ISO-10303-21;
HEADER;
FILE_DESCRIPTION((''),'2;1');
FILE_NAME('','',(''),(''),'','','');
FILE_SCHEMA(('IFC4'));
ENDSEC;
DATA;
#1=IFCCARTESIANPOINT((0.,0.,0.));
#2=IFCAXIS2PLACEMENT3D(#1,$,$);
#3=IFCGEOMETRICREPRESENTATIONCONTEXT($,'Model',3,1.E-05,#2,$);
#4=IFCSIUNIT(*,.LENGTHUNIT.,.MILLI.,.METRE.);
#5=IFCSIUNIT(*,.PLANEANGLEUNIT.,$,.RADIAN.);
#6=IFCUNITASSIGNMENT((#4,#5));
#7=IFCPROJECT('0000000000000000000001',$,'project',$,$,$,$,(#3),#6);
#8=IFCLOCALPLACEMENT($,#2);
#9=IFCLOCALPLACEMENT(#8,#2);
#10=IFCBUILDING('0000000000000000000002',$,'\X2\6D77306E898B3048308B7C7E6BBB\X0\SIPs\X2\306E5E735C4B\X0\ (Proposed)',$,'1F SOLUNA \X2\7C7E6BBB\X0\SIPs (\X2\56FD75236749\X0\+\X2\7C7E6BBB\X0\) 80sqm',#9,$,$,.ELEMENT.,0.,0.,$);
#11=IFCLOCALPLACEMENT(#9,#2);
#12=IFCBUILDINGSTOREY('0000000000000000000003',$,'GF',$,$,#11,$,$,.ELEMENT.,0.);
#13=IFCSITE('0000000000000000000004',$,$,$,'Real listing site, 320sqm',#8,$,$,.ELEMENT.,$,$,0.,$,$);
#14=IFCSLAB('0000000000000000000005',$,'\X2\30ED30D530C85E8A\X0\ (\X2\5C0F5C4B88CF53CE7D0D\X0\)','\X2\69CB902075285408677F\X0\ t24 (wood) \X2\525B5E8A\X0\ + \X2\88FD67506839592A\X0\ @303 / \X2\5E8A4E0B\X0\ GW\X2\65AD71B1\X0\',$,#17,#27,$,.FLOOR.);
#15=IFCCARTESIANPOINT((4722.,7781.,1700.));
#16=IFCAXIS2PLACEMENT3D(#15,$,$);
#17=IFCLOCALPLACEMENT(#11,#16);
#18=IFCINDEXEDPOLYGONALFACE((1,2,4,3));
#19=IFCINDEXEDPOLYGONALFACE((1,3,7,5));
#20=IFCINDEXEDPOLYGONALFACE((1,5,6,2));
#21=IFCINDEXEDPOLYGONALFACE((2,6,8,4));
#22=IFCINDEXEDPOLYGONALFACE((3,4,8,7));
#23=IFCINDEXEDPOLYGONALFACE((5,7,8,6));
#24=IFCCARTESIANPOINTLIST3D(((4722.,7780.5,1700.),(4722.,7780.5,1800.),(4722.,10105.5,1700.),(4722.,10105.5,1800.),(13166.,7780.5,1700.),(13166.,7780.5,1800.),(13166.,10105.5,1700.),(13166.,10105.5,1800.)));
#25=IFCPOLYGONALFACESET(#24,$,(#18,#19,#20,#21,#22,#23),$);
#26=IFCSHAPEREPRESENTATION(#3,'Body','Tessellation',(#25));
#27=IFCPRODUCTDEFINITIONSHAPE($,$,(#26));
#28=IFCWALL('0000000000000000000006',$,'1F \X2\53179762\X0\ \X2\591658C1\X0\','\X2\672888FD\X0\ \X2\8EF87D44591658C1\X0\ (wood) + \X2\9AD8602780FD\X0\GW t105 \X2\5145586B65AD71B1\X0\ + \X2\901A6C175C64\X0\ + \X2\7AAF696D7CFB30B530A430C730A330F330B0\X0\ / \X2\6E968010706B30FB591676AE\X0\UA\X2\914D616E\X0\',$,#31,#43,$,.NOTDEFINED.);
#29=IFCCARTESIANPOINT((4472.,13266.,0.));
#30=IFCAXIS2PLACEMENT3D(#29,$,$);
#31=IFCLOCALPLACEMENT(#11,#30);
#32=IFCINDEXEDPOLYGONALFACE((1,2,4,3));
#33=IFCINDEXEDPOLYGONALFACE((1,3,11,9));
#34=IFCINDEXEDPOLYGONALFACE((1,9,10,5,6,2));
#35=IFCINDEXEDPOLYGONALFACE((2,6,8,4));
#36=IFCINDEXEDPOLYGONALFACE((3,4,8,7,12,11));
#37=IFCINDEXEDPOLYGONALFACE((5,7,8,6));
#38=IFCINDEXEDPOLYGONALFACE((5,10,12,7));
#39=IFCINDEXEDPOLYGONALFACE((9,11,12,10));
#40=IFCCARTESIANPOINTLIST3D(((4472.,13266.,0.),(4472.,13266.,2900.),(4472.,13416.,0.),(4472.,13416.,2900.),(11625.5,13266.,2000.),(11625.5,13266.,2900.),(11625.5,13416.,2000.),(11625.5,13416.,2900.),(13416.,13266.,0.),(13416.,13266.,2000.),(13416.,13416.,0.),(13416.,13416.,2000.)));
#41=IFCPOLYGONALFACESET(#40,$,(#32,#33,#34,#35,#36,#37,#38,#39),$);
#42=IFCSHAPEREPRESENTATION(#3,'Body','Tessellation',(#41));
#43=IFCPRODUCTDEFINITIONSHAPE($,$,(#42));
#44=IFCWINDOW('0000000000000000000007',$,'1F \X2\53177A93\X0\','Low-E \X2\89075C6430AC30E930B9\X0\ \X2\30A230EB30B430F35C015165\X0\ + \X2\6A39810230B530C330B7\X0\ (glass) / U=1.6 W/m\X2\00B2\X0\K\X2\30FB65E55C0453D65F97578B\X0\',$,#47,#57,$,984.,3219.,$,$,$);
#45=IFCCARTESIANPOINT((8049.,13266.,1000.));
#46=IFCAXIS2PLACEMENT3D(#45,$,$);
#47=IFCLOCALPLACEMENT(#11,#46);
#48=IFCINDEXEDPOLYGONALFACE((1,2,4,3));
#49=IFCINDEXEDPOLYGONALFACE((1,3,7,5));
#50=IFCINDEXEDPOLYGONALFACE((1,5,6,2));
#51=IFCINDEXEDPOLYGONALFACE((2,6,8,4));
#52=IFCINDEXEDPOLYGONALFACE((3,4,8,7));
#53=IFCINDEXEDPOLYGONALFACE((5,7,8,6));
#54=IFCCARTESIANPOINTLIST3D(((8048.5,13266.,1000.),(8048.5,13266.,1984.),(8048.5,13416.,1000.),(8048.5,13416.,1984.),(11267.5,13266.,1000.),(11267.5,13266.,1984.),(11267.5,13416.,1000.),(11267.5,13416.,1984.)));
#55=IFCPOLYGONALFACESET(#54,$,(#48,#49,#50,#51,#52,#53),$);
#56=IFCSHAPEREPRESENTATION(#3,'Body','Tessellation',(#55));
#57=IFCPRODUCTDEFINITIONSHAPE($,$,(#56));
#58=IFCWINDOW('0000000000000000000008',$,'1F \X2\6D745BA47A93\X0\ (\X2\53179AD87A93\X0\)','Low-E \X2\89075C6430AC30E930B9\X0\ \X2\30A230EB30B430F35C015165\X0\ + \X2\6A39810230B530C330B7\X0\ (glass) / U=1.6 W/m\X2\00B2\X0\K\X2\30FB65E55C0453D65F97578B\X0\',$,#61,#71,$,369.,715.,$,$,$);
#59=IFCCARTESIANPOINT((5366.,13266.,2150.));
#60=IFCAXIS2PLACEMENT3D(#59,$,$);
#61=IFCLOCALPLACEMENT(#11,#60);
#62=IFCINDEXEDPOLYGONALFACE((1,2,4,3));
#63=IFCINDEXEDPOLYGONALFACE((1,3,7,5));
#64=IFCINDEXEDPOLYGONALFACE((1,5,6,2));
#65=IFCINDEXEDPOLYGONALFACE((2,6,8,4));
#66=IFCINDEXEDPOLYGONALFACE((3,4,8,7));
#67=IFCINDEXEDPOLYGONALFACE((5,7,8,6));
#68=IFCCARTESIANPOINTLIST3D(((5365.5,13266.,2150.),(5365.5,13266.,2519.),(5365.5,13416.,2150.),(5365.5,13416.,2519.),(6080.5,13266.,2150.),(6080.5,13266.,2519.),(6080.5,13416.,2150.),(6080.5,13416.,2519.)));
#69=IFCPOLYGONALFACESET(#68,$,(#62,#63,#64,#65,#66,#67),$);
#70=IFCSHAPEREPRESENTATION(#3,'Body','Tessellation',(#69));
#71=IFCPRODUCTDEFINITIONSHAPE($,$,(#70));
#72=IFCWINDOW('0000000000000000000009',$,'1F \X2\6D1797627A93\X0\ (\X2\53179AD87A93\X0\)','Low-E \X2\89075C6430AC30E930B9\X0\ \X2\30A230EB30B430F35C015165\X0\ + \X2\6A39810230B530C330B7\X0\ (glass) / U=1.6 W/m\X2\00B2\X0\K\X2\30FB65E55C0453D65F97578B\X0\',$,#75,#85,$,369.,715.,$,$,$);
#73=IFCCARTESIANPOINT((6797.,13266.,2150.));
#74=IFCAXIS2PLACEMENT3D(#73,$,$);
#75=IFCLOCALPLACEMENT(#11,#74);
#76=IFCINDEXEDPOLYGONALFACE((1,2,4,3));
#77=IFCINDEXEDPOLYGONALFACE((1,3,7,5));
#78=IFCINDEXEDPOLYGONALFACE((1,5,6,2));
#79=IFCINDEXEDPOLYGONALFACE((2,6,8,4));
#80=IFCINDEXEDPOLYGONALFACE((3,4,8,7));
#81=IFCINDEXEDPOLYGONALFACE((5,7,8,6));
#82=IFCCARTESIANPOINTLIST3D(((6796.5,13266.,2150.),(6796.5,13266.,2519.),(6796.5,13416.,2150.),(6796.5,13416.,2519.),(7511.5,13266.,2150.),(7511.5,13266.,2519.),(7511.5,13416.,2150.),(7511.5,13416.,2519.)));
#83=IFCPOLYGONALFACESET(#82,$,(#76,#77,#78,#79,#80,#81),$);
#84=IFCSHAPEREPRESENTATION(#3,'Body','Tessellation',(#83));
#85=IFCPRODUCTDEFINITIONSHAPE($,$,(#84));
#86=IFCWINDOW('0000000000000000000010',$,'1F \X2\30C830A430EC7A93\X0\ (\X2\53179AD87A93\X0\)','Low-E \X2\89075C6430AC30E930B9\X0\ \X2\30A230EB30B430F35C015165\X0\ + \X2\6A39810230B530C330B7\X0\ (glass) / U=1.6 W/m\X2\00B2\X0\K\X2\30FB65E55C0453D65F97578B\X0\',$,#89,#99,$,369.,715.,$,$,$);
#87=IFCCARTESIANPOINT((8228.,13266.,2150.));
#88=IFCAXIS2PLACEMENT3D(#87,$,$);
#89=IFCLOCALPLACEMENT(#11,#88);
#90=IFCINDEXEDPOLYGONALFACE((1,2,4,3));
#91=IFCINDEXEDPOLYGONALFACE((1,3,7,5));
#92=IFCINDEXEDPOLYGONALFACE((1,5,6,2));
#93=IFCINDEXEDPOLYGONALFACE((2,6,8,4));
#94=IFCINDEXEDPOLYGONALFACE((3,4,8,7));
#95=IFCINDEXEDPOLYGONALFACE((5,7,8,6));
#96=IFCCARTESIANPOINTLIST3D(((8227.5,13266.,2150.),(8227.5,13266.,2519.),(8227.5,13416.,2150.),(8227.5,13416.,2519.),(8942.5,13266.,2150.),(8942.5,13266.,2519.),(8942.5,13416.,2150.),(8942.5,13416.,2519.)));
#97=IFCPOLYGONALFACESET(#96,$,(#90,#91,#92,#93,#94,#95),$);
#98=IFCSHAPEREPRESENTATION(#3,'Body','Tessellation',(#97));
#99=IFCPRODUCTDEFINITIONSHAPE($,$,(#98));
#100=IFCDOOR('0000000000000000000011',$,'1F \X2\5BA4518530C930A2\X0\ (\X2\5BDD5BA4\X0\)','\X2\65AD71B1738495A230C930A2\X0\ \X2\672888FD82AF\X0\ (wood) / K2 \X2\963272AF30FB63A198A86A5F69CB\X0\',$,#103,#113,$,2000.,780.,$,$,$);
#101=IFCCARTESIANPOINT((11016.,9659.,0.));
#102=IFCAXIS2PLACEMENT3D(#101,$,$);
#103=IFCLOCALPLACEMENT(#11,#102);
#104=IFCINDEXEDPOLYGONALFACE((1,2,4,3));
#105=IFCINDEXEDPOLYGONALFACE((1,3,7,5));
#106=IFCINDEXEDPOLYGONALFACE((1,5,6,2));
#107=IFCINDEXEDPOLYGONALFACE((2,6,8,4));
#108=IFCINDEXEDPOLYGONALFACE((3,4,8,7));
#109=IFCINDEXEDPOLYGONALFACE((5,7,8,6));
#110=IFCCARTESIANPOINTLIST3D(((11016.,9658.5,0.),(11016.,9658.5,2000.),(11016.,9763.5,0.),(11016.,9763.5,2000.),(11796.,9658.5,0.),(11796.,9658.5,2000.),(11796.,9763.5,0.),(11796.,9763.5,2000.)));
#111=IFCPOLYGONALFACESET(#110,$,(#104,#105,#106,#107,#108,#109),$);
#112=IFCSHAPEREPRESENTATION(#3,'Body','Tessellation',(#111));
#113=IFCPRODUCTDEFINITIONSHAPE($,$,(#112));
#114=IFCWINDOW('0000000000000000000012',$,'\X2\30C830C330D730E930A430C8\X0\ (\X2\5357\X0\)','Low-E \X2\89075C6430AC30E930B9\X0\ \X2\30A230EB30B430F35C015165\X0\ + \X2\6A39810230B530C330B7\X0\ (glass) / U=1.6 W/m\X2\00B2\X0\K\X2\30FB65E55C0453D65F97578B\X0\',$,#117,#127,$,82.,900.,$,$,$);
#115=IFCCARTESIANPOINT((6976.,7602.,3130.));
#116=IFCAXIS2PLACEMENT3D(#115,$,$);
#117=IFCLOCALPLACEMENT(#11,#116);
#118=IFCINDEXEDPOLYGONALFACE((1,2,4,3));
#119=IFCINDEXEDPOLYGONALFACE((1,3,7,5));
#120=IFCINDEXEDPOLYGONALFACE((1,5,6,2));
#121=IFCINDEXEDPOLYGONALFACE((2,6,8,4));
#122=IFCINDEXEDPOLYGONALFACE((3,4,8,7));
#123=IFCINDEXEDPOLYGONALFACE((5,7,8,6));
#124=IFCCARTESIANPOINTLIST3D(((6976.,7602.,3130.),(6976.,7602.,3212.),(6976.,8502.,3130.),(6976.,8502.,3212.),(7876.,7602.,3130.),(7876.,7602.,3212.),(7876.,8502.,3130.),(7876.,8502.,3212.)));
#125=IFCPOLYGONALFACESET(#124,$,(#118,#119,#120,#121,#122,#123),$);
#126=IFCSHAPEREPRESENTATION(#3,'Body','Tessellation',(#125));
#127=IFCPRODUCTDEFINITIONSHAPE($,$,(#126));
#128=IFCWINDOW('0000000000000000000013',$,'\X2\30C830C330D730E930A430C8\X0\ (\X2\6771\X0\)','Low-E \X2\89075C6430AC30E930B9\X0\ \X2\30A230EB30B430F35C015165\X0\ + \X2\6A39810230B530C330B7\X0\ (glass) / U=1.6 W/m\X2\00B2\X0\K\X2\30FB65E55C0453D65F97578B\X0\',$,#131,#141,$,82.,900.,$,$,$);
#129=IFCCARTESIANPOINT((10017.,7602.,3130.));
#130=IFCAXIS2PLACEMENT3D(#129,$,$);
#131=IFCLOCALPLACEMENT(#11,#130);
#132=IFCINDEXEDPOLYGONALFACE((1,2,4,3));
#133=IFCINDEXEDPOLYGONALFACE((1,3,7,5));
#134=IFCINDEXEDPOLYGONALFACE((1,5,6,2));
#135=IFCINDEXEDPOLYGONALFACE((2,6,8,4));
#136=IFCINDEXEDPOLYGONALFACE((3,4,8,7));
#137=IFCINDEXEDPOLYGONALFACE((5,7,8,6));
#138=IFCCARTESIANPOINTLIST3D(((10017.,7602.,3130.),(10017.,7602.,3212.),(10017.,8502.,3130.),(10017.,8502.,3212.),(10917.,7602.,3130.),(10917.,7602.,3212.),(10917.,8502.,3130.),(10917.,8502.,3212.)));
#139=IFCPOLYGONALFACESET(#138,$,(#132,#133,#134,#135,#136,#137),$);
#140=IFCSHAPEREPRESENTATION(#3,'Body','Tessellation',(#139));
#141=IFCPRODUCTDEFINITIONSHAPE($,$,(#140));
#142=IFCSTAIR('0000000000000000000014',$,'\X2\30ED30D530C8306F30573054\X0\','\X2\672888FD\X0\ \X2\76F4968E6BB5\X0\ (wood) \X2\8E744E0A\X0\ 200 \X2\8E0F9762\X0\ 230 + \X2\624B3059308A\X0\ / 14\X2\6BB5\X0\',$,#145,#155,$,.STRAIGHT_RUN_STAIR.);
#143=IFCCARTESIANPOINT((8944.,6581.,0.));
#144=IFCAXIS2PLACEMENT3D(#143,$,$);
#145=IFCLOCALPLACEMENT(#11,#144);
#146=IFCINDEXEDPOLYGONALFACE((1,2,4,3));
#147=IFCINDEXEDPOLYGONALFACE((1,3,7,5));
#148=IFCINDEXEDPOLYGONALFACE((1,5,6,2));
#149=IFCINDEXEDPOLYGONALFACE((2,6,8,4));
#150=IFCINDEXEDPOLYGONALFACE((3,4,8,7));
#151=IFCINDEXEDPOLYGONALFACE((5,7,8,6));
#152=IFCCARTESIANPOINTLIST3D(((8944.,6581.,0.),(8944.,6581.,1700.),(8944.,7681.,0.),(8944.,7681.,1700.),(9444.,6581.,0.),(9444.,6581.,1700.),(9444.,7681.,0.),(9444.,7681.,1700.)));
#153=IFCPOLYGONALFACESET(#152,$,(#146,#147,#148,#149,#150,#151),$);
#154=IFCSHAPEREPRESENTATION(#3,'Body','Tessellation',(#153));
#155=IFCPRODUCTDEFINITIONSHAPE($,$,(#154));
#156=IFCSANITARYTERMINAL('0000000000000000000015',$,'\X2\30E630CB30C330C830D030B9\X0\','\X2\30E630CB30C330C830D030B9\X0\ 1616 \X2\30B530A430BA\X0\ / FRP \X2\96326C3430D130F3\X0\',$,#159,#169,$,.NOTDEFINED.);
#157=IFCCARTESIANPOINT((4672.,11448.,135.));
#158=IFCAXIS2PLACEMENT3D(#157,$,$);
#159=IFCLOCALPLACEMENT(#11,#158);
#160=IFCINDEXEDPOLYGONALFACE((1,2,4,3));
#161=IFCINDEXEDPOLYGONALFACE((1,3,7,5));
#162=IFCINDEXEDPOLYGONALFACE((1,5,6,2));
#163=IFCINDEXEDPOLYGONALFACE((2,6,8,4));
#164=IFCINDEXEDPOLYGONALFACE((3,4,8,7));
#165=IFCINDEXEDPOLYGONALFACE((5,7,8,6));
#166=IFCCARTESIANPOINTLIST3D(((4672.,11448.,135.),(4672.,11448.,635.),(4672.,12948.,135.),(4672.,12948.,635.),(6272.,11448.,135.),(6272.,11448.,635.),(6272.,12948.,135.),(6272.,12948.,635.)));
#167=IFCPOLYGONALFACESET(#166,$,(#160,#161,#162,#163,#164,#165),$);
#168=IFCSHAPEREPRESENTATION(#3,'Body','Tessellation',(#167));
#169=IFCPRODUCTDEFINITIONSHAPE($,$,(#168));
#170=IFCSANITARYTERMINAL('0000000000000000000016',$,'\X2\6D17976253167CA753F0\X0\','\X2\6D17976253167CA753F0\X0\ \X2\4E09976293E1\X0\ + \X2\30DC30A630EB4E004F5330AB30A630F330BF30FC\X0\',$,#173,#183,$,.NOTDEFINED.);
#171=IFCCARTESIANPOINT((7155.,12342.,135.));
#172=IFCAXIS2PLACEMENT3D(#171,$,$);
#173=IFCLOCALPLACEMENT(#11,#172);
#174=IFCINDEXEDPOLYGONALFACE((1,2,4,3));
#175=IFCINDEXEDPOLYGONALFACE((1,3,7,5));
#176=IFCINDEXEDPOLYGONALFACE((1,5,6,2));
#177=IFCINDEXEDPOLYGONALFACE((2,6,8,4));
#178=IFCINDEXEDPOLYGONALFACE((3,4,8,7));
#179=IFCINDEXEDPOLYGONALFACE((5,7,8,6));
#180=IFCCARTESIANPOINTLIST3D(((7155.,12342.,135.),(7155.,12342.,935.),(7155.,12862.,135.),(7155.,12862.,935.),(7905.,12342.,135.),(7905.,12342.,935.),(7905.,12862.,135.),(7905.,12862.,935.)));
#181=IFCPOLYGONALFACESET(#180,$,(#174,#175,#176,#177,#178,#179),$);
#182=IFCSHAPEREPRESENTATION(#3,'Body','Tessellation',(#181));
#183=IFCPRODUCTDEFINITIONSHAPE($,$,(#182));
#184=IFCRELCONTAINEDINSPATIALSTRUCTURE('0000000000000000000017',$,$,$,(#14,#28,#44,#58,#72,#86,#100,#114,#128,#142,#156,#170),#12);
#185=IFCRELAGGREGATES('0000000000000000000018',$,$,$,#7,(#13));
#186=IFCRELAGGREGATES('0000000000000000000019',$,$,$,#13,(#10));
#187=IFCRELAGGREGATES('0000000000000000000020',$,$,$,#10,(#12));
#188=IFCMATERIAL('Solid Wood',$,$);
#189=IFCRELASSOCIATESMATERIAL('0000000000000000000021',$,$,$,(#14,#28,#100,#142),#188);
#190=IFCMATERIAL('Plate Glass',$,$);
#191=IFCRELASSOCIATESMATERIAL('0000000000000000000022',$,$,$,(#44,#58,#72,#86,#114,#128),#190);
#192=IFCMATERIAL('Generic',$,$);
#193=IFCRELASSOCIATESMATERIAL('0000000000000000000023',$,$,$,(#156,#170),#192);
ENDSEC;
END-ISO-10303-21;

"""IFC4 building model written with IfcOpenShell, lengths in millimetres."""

from ifc_helpers import new_model, si_unit, frame, frame_2d, origin, place, context, project, spatial, rectangle, extrude, material, element, fill, save


model = new_model("IFC4")

# Units and contexts
model_context = context("Model", 3, precision=1e-05, world=origin())
ifc_project = project(units=[si_unit("LENGTHUNIT", "METRE", prefix="MILLI"), si_unit("PLANEANGLEUNIT", "RADIAN")], contexts=[model_context])

# Site, building, storey
site_placement = place(None, origin())
site = spatial("IfcSite", under=ifc_project, at=site_placement, ObjectType="Real listing site, 320sqm", CompositionType="ELEMENT", RefElevation=0.0)
building_placement = place(site_placement, origin())
building = spatial("IfcBuilding", under=site, at=building_placement, Name="海の見える籾殻SIPsの平屋 (Proposed)", ObjectType="1F SOLUNA 籾殻SIPs (国産杉+籾殻) 80sqm", CompositionType="ELEMENT", ElevationOfRefHeight=0.0, ElevationOfTerrain=0.0)
storey_placement = place(building_placement, origin())
storey = spatial("IfcBuildingStorey", under=building, at=storey_placement, Name="GF", CompositionType="ELEMENT", Elevation=0.0)

# Slab
ifc_material_1 = material(Name="Solid Wood")
slab_placement = place(storey_placement, frame((4722.0, 7781.0, 1700.0)))
element("IfcSlab", 1, at=slab_placement, inside=storey, material=ifc_material_1, Name="ロフト床 (小屋裏収納)", Description="構造用合板 t24 (wood) 剛床 + 製材根太 @303 / 床下 GW断熱", PredefinedType="FLOOR", context=model_context, shape_type="SweptSolid", body=[
    extrude(rectangle(XDim=8444.0, YDim=2325.0, at=frame_2d((4222.0, 1162.0))), frame((4722.0, 7781.0, 1700.0)), (0.0, 0.0, 1.0), 100.0),
])

# Wall, openings, windows
wall_1_placement = place(storey_placement, frame((4472.0, 13266.0, 0.0)))
wall_1 = element("IfcWall", 2, at=wall_1_placement, inside=storey, material=ifc_material_1, Name="1F 北面 外壁", Description="木製 軸組外壁 (wood) + 高性能GW t105 充填断熱 + 通気層 + 窯業系サイディング / 準耐火・外皮UA配慮", PredefinedType="NOTDEFINED", context=model_context, shape_type="SweptSolid", body=[
    extrude(rectangle(XDim=8944.0, YDim=150.0, at=frame_2d((4472.0, 75.0))), frame((4472.0, 13266.0, 0.0)), (0.0, 0.0, 1.0), 2900.0),
])
opening_1_placement = place(storey_placement, frame((8049.0, 13266.0, 1000.0)))
opening_1 = element("IfcOpeningElement", 3, at=opening_1_placement, cuts=wall_1, PredefinedType="NOTDEFINED", context=model_context, shape_type="SweptSolid", body=[
    extrude(rectangle(XDim=3219.0, YDim=150.0, at=frame_2d((1609.0, 75.0))), frame((8049.0, 13266.0, 1000.0)), (0.0, 0.0, 1.0), 984.0),
])
opening_2_placement = place(storey_placement, frame((5366.0, 13266.0, 2150.0)))
opening_2 = element("IfcOpeningElement", 4, at=opening_2_placement, cuts=wall_1, PredefinedType="NOTDEFINED", context=model_context, shape_type="SweptSolid", body=[
    extrude(rectangle(XDim=715.0, YDim=150.0, at=frame_2d((357.0, 75.0))), frame((5366.0, 13266.0, 2150.0)), (0.0, 0.0, 1.0), 369.0),
])
opening_3_placement = place(storey_placement, frame((6797.0, 13266.0, 2150.0)))
opening_3 = element("IfcOpeningElement", 5, at=opening_3_placement, cuts=wall_1, PredefinedType="NOTDEFINED", context=model_context, shape_type="SweptSolid", body=[
    extrude(rectangle(XDim=715.0, YDim=150.0, at=frame_2d((357.0, 75.0))), frame((6797.0, 13266.0, 2150.0)), (0.0, 0.0, 1.0), 369.0),
])
opening_4_placement = place(storey_placement, frame((8228.0, 13266.0, 2150.0)))
opening_4 = element("IfcOpeningElement", 6, at=opening_4_placement, cuts=wall_1, PredefinedType="NOTDEFINED", context=model_context, shape_type="SweptSolid", body=[
    extrude(rectangle(XDim=715.0, YDim=150.0, at=frame_2d((357.0, 75.0))), frame((8228.0, 13266.0, 2150.0)), (0.0, 0.0, 1.0), 369.0),
])
ifc_material_2 = material(Name="Plate Glass")
window_1_placement = place(storey_placement, frame((8049.0, 13266.0, 1000.0)))
window_1 = element("IfcWindow", 7, at=window_1_placement, inside=storey, material=ifc_material_2, Name="1F 北窓", Description="Low-E 複層ガラス アルゴン封入 + 樹脂サッシ (glass) / U=1.6 W/m²K・日射取得型", OverallHeight=984.0, OverallWidth=3219.0, context=model_context, shape_type="SweptSolid", body=[
    extrude(rectangle(XDim=3219.0, YDim=150.0, at=frame_2d((1609.0, 75.0))), frame((8049.0, 13266.0, 1000.0)), (0.0, 0.0, 1.0), 984.0),
])
fill(opening_1, window_1)
window_2_placement = place(storey_placement, frame((5366.0, 13266.0, 2150.0)))
window_2 = element("IfcWindow", 8, at=window_2_placement, inside=storey, material=ifc_material_2, Name="1F 浴室窓 (北高窓)", Description="Low-E 複層ガラス アルゴン封入 + 樹脂サッシ (glass) / U=1.6 W/m²K・日射取得型", OverallHeight=369.0, OverallWidth=715.0, context=model_context, shape_type="SweptSolid", body=[
    extrude(rectangle(XDim=715.0, YDim=150.0, at=frame_2d((357.0, 75.0))), frame((5366.0, 13266.0, 2150.0)), (0.0, 0.0, 1.0), 369.0),
])
fill(opening_2, window_2)
window_3_placement = place(storey_placement, frame((6797.0, 13266.0, 2150.0)))
window_3 = element("IfcWindow", 9, at=window_3_placement, inside=storey, material=ifc_material_2, Name="1F 洗面窓 (北高窓)", Description="Low-E 複層ガラス アルゴン封入 + 樹脂サッシ (glass) / U=1.6 W/m²K・日射取得型", OverallHeight=369.0, OverallWidth=715.0, context=model_context, shape_type="SweptSolid", body=[
    extrude(rectangle(XDim=715.0, YDim=150.0, at=frame_2d((357.0, 75.0))), frame((6797.0, 13266.0, 2150.0)), (0.0, 0.0, 1.0), 369.0),
])
fill(opening_3, window_3)
window_4_placement = place(storey_placement, frame((8228.0, 13266.0, 2150.0)))
window_4 = element("IfcWindow", 10, at=window_4_placement, inside=storey, material=ifc_material_2, Name="1F トイレ窓 (北高窓)", Description="Low-E 複層ガラス アルゴン封入 + 樹脂サッシ (glass) / U=1.6 W/m²K・日射取得型", OverallHeight=369.0, OverallWidth=715.0, context=model_context, shape_type="SweptSolid", body=[
    extrude(rectangle(XDim=715.0, YDim=150.0, at=frame_2d((357.0, 75.0))), frame((8228.0, 13266.0, 2150.0)), (0.0, 0.0, 1.0), 369.0),
])
fill(opening_4, window_4)

# Door
door_1_placement = place(storey_placement, frame((11016.0, 9659.0, 0.0)))
element("IfcDoor", 11, at=door_1_placement, inside=storey, material=ifc_material_1, Name="1F 室内ドア (寝室)", Description="断熱玄関ドア 木製芯 (wood) / K2 防犯・採風機構", OverallHeight=2000.0, OverallWidth=780.0, context=model_context, shape_type="SweptSolid", body=[
    extrude(rectangle(XDim=780.0, YDim=105.0, at=frame_2d((390.0, 52.0))), frame((11016.0, 9659.0, 0.0)), (0.0, 0.0, 1.0), 2000.0),
])

# Windows
window_5_placement = place(storey_placement, frame((6976.0, 7602.0, 3130.0)))
element("IfcWindow", 12, at=window_5_placement, inside=storey, material=ifc_material_2, Name="トップライト (南)", Description="Low-E 複層ガラス アルゴン封入 + 樹脂サッシ (glass) / U=1.6 W/m²K・日射取得型", OverallHeight=82.0, OverallWidth=900.0, context=model_context, shape_type="SweptSolid", body=[
    extrude(rectangle(XDim=900.0, YDim=900.0, at=frame_2d((450.0, 450.0))), frame((6976.0, 7602.0, 3130.0)), (0.0, 0.0, 1.0), 82.0),
])
window_6_placement = place(storey_placement, frame((10017.0, 7602.0, 3130.0)))
element("IfcWindow", 13, at=window_6_placement, inside=storey, material=ifc_material_2, Name="トップライト (東)", Description="Low-E 複層ガラス アルゴン封入 + 樹脂サッシ (glass) / U=1.6 W/m²K・日射取得型", OverallHeight=82.0, OverallWidth=900.0, context=model_context, shape_type="SweptSolid", body=[
    extrude(rectangle(XDim=900.0, YDim=900.0, at=frame_2d((450.0, 450.0))), frame((10017.0, 7602.0, 3130.0)), (0.0, 0.0, 1.0), 82.0),
])

# Stair
stair_placement = place(storey_placement, frame((8944.0, 6581.0, 0.0)))
element("IfcStair", 14, at=stair_placement, inside=storey, material=ifc_material_1, Name="ロフトはしご", Description="木製 直階段 (wood) 蹴上 200 踏面 230 + 手すり / 14段", PredefinedType="STRAIGHT_RUN_STAIR", context=model_context, shape_type="SweptSolid", body=[
    extrude(rectangle(XDim=500.0, YDim=1100.0, at=frame_2d((250.0, 550.0))), frame((8944.0, 6581.0, 0.0)), (0.0, 0.0, 1.0), 1700.0),
])

# Sanitary terminals
ifc_material_3 = material(Name="Generic")
sanitary_terminal_1_placement = place(storey_placement, frame((4672.0, 11448.0, 135.0)))
element("IfcSanitaryTerminal", 15, at=sanitary_terminal_1_placement, inside=storey, material=ifc_material_3, Name="ユニットバス", Description="ユニットバス 1616 サイズ / FRP 防水パン", PredefinedType="NOTDEFINED", context=model_context, shape_type="SweptSolid", body=[
    extrude(rectangle(XDim=1600.0, YDim=1500.0, at=frame_2d((800.0, 750.0))), frame((4672.0, 11448.0, 135.0)), (0.0, 0.0, 1.0), 500.0),
])
sanitary_terminal_2_placement = place(storey_placement, frame((7155.0, 12342.0, 135.0)))
element("IfcSanitaryTerminal", 16, at=sanitary_terminal_2_placement, inside=storey, material=ifc_material_3, Name="洗面化粧台", Description="洗面化粧台 三面鏡 + ボウル一体カウンター", PredefinedType="NOTDEFINED", context=model_context, shape_type="SweptSolid", body=[
    extrude(rectangle(XDim=750.0, YDim=520.0, at=frame_2d((375.0, 260.0))), frame((7155.0, 12342.0, 135.0)), (0.0, 0.0, 1.0), 800.0),
])

save(model, "model.ifc")
